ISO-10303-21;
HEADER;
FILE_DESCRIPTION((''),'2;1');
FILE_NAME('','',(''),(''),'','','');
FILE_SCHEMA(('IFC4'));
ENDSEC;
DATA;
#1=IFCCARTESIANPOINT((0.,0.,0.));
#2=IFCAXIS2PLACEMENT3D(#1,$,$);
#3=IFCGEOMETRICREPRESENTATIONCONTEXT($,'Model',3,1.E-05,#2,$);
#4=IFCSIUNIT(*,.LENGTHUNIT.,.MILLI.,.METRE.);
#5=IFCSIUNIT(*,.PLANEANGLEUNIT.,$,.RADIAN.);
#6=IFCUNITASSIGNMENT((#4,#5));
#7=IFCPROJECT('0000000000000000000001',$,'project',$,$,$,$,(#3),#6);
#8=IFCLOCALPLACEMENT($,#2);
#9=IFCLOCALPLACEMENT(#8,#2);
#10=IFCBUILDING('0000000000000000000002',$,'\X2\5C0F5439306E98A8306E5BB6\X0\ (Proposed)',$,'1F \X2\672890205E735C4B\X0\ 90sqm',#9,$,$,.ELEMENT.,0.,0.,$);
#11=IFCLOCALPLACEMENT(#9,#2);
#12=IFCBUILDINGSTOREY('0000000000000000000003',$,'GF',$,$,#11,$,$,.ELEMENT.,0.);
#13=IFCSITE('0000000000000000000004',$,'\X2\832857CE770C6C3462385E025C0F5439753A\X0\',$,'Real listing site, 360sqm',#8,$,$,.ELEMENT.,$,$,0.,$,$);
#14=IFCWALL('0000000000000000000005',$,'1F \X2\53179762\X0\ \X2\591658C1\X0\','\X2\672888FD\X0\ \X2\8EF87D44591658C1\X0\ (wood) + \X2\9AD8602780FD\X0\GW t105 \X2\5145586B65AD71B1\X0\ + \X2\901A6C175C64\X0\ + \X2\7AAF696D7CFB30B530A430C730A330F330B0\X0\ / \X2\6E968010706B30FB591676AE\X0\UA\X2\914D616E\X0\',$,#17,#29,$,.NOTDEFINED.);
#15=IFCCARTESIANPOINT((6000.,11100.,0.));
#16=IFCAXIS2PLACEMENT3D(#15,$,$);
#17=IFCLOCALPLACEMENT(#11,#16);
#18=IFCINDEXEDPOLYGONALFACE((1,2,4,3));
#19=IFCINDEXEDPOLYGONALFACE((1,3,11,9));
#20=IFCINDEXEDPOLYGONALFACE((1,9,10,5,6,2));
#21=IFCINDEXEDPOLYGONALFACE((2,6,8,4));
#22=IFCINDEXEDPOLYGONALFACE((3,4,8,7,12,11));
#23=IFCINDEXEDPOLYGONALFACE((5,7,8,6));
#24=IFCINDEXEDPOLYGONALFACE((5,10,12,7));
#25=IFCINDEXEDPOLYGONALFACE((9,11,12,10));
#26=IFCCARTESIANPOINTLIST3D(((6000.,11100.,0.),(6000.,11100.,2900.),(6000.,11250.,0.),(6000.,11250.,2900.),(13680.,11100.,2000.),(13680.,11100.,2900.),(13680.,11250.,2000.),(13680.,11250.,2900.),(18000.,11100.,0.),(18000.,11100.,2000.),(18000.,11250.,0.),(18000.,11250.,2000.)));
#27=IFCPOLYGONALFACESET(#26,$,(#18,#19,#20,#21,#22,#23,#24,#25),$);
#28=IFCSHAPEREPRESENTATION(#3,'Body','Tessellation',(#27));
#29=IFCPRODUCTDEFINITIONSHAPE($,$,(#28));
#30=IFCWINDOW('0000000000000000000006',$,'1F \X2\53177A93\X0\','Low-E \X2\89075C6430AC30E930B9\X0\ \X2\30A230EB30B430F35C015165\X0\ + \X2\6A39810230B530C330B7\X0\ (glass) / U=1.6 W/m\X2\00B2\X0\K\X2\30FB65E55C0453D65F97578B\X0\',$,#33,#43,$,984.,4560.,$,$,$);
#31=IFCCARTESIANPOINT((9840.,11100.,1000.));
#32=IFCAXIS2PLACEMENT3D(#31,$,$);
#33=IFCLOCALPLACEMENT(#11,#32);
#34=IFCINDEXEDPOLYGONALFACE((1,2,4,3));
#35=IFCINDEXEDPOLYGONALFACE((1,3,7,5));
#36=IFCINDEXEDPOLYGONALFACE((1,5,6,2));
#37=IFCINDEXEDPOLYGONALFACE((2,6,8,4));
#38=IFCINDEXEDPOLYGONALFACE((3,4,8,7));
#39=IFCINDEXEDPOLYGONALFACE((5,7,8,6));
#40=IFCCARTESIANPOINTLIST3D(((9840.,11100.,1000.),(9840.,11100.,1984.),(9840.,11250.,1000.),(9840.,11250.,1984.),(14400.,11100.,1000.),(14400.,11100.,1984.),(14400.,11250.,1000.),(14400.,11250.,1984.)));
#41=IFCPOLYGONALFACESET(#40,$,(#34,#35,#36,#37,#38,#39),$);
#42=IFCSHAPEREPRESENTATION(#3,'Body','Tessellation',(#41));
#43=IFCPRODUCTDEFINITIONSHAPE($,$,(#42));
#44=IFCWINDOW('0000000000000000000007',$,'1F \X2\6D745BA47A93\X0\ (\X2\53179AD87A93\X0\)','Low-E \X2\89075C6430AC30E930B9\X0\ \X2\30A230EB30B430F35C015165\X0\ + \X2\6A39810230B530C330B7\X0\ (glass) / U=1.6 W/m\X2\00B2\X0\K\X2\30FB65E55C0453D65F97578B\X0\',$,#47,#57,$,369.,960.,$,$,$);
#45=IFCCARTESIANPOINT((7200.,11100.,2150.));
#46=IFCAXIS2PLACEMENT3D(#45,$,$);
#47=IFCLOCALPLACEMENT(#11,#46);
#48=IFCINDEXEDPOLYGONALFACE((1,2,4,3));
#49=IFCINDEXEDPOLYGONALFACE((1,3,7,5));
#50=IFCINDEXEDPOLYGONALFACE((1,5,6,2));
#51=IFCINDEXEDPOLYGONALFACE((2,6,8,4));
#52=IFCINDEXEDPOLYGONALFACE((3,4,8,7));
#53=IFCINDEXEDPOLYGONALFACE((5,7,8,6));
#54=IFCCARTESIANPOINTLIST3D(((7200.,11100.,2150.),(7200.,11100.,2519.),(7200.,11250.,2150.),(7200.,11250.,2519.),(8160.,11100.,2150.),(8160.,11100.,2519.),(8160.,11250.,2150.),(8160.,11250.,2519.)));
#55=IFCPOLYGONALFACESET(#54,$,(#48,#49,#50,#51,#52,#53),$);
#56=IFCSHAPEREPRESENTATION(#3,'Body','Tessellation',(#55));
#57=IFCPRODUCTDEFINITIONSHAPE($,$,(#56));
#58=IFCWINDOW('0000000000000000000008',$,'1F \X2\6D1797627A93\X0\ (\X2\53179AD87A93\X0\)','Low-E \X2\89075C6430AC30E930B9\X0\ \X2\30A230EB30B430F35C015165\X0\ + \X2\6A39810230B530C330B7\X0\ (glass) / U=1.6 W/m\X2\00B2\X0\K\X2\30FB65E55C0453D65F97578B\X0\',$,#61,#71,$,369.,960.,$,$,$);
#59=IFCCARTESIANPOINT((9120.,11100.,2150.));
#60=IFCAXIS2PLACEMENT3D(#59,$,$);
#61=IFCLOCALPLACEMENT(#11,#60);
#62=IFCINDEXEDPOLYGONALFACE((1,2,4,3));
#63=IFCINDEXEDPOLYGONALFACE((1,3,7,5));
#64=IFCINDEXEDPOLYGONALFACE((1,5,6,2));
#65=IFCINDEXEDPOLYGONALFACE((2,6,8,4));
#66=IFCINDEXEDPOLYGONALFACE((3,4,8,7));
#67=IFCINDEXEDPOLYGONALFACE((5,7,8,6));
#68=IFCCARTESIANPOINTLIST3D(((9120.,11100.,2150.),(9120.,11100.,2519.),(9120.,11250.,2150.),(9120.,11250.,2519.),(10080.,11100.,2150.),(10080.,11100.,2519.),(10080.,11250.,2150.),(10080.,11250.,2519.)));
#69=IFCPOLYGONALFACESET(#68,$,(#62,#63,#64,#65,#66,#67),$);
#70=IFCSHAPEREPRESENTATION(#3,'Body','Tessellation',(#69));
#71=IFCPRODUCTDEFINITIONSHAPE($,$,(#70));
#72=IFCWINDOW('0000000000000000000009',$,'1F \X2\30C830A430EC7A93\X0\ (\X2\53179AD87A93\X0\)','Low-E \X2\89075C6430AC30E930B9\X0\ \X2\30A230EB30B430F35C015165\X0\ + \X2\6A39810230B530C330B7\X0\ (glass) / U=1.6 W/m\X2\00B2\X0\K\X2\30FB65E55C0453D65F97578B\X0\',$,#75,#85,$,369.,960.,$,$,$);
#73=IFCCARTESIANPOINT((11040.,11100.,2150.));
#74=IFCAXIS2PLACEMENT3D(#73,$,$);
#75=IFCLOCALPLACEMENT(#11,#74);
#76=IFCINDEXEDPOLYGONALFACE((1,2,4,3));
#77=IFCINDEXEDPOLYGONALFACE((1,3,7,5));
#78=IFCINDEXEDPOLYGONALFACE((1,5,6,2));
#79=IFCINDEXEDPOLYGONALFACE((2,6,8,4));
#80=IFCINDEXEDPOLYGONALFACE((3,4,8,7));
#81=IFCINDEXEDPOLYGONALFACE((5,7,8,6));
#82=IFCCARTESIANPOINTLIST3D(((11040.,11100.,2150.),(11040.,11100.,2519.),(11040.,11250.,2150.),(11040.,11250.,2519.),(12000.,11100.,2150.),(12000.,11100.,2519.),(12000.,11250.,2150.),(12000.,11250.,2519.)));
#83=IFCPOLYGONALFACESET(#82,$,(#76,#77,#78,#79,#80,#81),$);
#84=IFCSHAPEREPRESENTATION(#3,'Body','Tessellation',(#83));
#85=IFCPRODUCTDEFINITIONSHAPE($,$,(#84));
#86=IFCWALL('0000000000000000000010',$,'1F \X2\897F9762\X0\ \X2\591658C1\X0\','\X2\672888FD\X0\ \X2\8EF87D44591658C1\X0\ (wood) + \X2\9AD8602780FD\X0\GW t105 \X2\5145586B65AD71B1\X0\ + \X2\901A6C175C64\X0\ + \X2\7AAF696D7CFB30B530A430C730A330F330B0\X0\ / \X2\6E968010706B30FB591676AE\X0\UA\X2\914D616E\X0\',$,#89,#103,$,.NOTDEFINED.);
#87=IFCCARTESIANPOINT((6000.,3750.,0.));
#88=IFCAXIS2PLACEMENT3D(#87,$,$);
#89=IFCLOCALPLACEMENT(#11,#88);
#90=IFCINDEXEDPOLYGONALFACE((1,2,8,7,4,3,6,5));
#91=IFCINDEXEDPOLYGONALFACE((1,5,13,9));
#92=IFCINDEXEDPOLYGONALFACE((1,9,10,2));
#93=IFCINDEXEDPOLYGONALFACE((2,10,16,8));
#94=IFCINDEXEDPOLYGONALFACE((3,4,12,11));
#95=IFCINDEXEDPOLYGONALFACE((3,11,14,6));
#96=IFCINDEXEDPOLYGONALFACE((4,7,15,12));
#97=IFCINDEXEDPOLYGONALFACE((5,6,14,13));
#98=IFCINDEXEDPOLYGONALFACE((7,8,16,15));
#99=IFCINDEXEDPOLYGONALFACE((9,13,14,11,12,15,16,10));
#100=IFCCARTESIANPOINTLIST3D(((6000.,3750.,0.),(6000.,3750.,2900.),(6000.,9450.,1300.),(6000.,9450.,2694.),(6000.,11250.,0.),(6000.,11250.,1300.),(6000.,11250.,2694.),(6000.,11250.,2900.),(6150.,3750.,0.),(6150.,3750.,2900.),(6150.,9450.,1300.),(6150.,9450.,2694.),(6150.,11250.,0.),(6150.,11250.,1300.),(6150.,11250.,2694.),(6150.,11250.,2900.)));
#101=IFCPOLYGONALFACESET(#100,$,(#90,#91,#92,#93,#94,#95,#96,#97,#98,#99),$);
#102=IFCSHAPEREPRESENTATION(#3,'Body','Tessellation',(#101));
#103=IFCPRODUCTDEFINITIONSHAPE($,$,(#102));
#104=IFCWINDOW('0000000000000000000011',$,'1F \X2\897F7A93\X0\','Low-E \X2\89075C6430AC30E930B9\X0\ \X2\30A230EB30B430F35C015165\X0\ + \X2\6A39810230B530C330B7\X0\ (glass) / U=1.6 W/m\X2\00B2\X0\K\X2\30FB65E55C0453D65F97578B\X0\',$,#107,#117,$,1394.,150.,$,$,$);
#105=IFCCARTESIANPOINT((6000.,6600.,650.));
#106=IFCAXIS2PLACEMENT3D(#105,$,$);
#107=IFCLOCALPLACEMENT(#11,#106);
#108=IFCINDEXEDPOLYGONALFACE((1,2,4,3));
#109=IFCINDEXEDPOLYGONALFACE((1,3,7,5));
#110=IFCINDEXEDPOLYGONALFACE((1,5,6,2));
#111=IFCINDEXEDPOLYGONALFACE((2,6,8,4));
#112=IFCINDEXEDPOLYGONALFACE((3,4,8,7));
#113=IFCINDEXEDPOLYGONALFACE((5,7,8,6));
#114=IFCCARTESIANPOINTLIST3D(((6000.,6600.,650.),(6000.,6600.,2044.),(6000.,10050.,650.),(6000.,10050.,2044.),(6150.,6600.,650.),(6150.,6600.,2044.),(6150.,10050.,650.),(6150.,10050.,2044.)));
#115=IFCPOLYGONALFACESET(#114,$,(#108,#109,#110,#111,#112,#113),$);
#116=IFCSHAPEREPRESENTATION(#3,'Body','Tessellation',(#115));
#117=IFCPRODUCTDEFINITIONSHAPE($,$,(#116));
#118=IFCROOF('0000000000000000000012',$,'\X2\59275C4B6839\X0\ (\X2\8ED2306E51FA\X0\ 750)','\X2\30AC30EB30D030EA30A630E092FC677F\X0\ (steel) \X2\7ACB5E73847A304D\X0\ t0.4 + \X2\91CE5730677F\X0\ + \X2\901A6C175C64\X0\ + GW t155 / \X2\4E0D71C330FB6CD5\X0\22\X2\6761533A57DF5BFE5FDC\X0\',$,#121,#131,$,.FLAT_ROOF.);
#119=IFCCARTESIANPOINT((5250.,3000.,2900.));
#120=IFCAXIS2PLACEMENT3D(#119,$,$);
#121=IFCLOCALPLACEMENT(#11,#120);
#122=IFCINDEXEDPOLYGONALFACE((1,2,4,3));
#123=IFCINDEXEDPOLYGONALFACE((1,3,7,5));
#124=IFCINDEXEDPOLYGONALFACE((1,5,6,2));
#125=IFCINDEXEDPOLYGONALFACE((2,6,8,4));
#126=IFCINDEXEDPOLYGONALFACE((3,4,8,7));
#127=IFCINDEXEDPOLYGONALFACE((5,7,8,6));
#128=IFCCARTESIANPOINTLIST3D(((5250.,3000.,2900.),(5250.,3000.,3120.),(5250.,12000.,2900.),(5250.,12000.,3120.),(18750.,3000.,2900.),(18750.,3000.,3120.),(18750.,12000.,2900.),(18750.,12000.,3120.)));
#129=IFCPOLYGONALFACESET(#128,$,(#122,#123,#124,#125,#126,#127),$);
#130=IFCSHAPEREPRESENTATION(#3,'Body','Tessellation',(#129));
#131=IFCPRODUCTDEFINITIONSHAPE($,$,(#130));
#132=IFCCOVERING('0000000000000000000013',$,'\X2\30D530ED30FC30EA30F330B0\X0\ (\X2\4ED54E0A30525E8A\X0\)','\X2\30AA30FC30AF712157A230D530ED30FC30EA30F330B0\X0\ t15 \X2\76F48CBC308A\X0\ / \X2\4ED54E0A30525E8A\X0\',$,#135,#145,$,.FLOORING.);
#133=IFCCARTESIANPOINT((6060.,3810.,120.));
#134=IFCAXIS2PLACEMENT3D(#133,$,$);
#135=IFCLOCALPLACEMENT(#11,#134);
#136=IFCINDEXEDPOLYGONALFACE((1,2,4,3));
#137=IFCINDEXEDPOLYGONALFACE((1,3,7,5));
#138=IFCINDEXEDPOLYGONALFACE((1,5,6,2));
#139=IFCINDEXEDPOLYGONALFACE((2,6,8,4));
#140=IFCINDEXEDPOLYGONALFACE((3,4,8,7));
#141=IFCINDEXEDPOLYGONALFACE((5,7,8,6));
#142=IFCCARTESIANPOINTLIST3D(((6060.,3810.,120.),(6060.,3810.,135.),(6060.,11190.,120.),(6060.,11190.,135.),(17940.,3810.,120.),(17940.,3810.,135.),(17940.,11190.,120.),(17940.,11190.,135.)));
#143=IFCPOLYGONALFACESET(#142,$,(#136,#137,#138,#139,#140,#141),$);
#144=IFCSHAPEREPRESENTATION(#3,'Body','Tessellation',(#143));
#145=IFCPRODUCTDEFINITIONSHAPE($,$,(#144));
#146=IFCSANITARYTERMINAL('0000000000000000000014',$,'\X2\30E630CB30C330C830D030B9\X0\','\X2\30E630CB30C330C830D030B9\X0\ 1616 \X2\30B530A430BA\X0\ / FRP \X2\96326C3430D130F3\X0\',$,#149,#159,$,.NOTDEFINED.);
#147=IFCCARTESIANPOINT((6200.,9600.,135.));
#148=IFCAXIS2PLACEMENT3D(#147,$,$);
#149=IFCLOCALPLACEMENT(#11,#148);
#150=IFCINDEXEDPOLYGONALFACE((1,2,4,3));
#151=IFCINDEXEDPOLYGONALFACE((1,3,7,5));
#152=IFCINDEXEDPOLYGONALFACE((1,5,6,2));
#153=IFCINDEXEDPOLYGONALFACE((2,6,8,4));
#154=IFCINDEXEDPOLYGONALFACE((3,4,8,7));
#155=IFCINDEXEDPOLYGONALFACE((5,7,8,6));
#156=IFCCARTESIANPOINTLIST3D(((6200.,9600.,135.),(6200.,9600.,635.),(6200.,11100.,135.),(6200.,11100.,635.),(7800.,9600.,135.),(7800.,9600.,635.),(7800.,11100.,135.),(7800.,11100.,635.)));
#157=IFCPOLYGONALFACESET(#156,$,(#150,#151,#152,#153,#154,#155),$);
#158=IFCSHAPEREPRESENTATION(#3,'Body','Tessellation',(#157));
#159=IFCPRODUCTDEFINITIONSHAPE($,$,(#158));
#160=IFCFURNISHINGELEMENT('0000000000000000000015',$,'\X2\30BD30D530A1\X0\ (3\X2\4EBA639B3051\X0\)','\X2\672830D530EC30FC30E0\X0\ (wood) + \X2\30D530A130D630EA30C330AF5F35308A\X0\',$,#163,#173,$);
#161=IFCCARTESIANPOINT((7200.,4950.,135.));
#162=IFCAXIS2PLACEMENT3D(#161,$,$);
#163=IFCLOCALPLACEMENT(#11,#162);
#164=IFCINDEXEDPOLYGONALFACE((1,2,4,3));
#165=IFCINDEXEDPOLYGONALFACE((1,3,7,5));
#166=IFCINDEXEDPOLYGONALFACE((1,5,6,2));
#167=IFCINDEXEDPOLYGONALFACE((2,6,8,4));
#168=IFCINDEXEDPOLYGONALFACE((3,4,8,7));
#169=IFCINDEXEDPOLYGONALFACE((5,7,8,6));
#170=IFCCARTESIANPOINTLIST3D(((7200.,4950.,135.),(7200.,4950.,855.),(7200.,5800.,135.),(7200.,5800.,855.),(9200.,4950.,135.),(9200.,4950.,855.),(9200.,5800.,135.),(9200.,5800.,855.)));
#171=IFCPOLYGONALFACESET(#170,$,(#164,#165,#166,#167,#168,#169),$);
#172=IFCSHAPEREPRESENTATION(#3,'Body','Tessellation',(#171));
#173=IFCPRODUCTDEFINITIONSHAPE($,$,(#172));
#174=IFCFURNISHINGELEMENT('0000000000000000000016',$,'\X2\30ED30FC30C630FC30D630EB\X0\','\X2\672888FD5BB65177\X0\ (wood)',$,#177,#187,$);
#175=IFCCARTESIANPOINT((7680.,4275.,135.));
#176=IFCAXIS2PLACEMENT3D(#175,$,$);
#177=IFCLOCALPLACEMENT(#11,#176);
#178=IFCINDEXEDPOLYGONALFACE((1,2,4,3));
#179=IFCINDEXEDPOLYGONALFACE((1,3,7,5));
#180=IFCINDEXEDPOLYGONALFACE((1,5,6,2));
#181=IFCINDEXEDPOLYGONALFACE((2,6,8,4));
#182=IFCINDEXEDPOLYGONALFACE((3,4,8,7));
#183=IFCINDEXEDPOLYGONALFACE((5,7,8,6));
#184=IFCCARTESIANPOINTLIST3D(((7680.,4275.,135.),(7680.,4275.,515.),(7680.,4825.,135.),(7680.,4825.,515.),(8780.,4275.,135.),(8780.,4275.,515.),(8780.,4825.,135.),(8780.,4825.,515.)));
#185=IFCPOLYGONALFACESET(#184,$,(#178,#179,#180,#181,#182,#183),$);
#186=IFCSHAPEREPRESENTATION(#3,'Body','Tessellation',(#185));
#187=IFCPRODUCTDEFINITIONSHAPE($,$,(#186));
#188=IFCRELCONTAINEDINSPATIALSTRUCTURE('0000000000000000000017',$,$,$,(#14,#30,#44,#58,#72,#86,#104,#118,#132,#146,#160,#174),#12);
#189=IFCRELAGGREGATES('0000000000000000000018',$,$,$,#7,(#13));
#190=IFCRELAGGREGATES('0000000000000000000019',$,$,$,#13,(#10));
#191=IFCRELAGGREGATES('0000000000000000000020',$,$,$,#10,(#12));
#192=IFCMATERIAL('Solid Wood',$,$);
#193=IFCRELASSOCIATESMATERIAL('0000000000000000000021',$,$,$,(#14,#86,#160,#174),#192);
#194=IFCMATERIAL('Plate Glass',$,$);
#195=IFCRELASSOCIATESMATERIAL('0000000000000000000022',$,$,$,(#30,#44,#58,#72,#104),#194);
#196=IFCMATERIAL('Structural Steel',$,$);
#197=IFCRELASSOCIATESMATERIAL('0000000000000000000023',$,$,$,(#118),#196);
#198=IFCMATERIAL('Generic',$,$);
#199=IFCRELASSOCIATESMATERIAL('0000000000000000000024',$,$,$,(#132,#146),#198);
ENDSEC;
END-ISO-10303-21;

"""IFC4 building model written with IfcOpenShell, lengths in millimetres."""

from ifc_helpers import new_model, si_unit, frame, frame_2d, origin, place, context, project, spatial, rectangle, extrude, material, element, fill, save


model = new_model("IFC4")

# Units and contexts
model_context = context("Model", 3, precision=1e-05, world=origin())
ifc_project = project(units=[si_unit("LENGTHUNIT", "METRE", prefix="MILLI"), si_unit("PLANEANGLEUNIT", "RADIAN")], contexts=[model_context])

# Site, building, storey
site_placement = place(None, origin())
site = spatial("IfcSite", under=ifc_project, at=site_placement, Name="茨城県水戸市小吹町", ObjectType="Real listing site, 360sqm", CompositionType="ELEMENT", RefElevation=0.0)
building_placement = place(site_placement, origin())
building = spatial("IfcBuilding", under=site, at=building_placement, Name="小吹の風の家 (Proposed)", ObjectType="1F 木造平屋 90sqm", CompositionType="ELEMENT", ElevationOfRefHeight=0.0, ElevationOfTerrain=0.0)
storey_placement = place(building_placement, origin())
storey = spatial("IfcBuildingStorey", under=building, at=storey_placement, Name="GF", CompositionType="ELEMENT", Elevation=0.0)

# Shared definitions
ifc_material_1 = material(Name="Solid Wood")

# Shared definitions
ifc_material_2 = material(Name="Plate Glass")

# Wall, openings, windows
wall_1_placement = place(storey_placement, frame((6000.0, 11100.0, 0.0)))
wall_1 = element("IfcWall", 1, at=wall_1_placement, inside=storey, material=ifc_material_1, Name="1F 北面 外壁", Description="木製 軸組外壁 (wood) + 高性能GW t105 充填断熱 + 通気層 + 窯業系サイディング / 準耐火・外皮UA配慮", PredefinedType="NOTDEFINED", context=model_context, shape_type="SweptSolid", body=[
    extrude(rectangle(XDim=12000.0, YDim=150.0, at=frame_2d((6000.0, 75.0))), frame((6000.0, 11100.0, 0.0)), (0.0, 0.0, 1.0), 2900.0),
])
opening_1_placement = place(storey_placement, frame((9840.0, 11100.0, 1000.0)))
opening_1 = element("IfcOpeningElement", 2, at=opening_1_placement, cuts=wall_1, PredefinedType="NOTDEFINED", context=model_context, shape_type="SweptSolid", body=[
    extrude(rectangle(XDim=4560.0, YDim=150.0, at=frame_2d((2280.0, 75.0))), frame((9840.0, 11100.0, 1000.0)), (0.0, 0.0, 1.0), 984.0),
])
opening_2_placement = place(storey_placement, frame((7200.0, 11100.0, 2150.0)))
opening_2 = element("IfcOpeningElement", 3, at=opening_2_placement, cuts=wall_1, PredefinedType="NOTDEFINED", context=model_context, shape_type="SweptSolid", body=[
    extrude(rectangle(XDim=960.0, YDim=150.0, at=frame_2d((480.0, 75.0))), frame((7200.0, 11100.0, 2150.0)), (0.0, 0.0, 1.0), 369.0),
])
opening_3_placement = place(storey_placement, frame((9120.0, 11100.0, 2150.0)))
opening_3 = element("IfcOpeningElement", 4, at=opening_3_placement, cuts=wall_1, PredefinedType="NOTDEFINED", context=model_context, shape_type="SweptSolid", body=[
    extrude(rectangle(XDim=960.0, YDim=150.0, at=frame_2d((480.0, 75.0))), frame((9120.0, 11100.0, 2150.0)), (0.0, 0.0, 1.0), 369.0),
])
opening_4_placement = place(storey_placement, frame((11040.0, 11100.0, 2150.0)))
opening_4 = element("IfcOpeningElement", 5, at=opening_4_placement, cuts=wall_1, PredefinedType="NOTDEFINED", context=model_context, shape_type="SweptSolid", body=[
    extrude(rectangle(XDim=960.0, YDim=150.0, at=frame_2d((480.0, 75.0))), frame((11040.0, 11100.0, 2150.0)), (0.0, 0.0, 1.0), 369.0),
])
window_1_placement = place(storey_placement, frame((9840.0, 11100.0, 1000.0)))
window_1 = element("IfcWindow", 6, at=window_1_placement, inside=storey, material=ifc_material_2, Name="1F 北窓", Description="Low-E 複層ガラス アルゴン封入 + 樹脂サッシ (glass) / U=1.6 W/m²K・日射取得型", OverallHeight=984.0, OverallWidth=4560.0, context=model_context, shape_type="SweptSolid", body=[
    extrude(rectangle(XDim=4560.0, YDim=150.0, at=frame_2d((2280.0, 75.0))), frame((9840.0, 11100.0, 1000.0)), (0.0, 0.0, 1.0), 984.0),
])
fill(opening_1, window_1)
window_2_placement = place(storey_placement, frame((7200.0, 11100.0, 2150.0)))
window_2 = element("IfcWindow", 7, at=window_2_placement, inside=storey, material=ifc_material_2, Name="1F 浴室窓 (北高窓)", Description="Low-E 複層ガラス アルゴン封入 + 樹脂サッシ (glass) / U=1.6 W/m²K・日射取得型", OverallHeight=369.0, OverallWidth=960.0, context=model_context, shape_type="SweptSolid", body=[
    extrude(rectangle(XDim=960.0, YDim=150.0, at=frame_2d((480.0, 75.0))), frame((7200.0, 11100.0, 2150.0)), (0.0, 0.0, 1.0), 369.0),
])
fill(opening_2, window_2)
window_3_placement = place(storey_placement, frame((9120.0, 11100.0, 2150.0)))
window_3 = element("IfcWindow", 8, at=window_3_placement, inside=storey, material=ifc_material_2, Name="1F 洗面窓 (北高窓)", Description="Low-E 複層ガラス アルゴン封入 + 樹脂サッシ (glass) / U=1.6 W/m²K・日射取得型", OverallHeight=369.0, OverallWidth=960.0, context=model_context, shape_type="SweptSolid", body=[
    extrude(rectangle(XDim=960.0, YDim=150.0, at=frame_2d((480.0, 75.0))), frame((9120.0, 11100.0, 2150.0)), (0.0, 0.0, 1.0), 369.0),
])
fill(opening_3, window_3)
window_4_placement = place(storey_placement, frame((11040.0, 11100.0, 2150.0)))
window_4 = element("IfcWindow", 9, at=window_4_placement, inside=storey, material=ifc_material_2, Name="1F トイレ窓 (北高窓)", Description="Low-E 複層ガラス アルゴン封入 + 樹脂サッシ (glass) / U=1.6 W/m²K・日射取得型", OverallHeight=369.0, OverallWidth=960.0, context=model_context, shape_type="SweptSolid", body=[
    extrude(rectangle(XDim=960.0, YDim=150.0, at=frame_2d((480.0, 75.0))), frame((11040.0, 11100.0, 2150.0)), (0.0, 0.0, 1.0), 369.0),
])
fill(opening_4, window_4)

# Wall, opening, window
wall_2_placement = place(storey_placement, frame((6000.0, 3750.0, 0.0)))
wall_2 = element("IfcWall", 10, at=wall_2_placement, inside=storey, material=ifc_material_1, Name="1F 西面 外壁", Description="木製 軸組外壁 (wood) + 高性能GW t105 充填断熱 + 通気層 + 窯業系サイディング / 準耐火・外皮UA配慮", PredefinedType="NOTDEFINED", context=model_context, shape_type="SweptSolid", body=[
    extrude(rectangle(XDim=150.0, YDim=7500.0, at=frame_2d((75.0, 3750.0))), frame((6000.0, 3750.0, 0.0)), (0.0, 0.0, 1.0), 2900.0),
])
opening_5_placement = place(storey_placement, frame((6000.0, 6600.0, 650.0)))
opening_5 = element("IfcOpeningElement", 11, at=opening_5_placement, cuts=wall_2, PredefinedType="NOTDEFINED", context=model_context, shape_type="SweptSolid", body=[
    extrude(rectangle(XDim=150.0, YDim=3450.0, at=frame_2d((75.0, 1725.0))), frame((6000.0, 6600.0, 650.0)), (0.0, 0.0, 1.0), 1394.0),
])
window_5_placement = place(storey_placement, frame((6000.0, 6600.0, 650.0)))
window_5 = element("IfcWindow", 12, at=window_5_placement, inside=storey, material=ifc_material_2, Name="1F 西窓", Description="Low-E 複層ガラス アルゴン封入 + 樹脂サッシ (glass) / U=1.6 W/m²K・日射取得型", OverallHeight=1394.0, OverallWidth=150.0, context=model_context, shape_type="SweptSolid", body=[
    extrude(rectangle(XDim=150.0, YDim=3450.0, at=frame_2d((75.0, 1725.0))), frame((6000.0, 6600.0, 650.0)), (0.0, 0.0, 1.0), 1394.0),
])
fill(opening_5, window_5)

# Roof
ifc_material_3 = material(Name="Structural Steel")
roof_placement = place(storey_placement, frame((5250.0, 3000.0, 2900.0)))
element("IfcRoof", 13, at=roof_placement, inside=storey, material=ifc_material_3, Name="大屋根 (軒の出 750)", Description="ガルバリウム鋼板 (steel) 立平葺き t0.4 + 野地板 + 通気層 + GW t155 / 不燃・法22条区域対応", PredefinedType="FLAT_ROOF", context=model_context, shape_type="SweptSolid", body=[
    extrude(rectangle(XDim=13500.0, YDim=9000.0, at=frame_2d((6750.0, 4500.0))), frame((5250.0, 3000.0, 2900.0)), (0.0, 0.0, 1.0), 220.0),
])

# Covering
ifc_material_4 = material(Name="Generic")
covering_placement = place(storey_placement, frame((6060.0, 3810.0, 120.0)))
element("IfcCovering", 14, at=covering_placement, inside=storey, material=ifc_material_4, Name="フローリング (仕上げ床)", Description="オーク無垢フローリング t15 直貼り / 仕上げ床", PredefinedType="FLOORING", context=model_context, shape_type="SweptSolid", body=[
    extrude(rectangle(XDim=11880.0, YDim=7380.0, at=frame_2d((5940.0, 3690.0))), frame((6060.0, 3810.0, 120.0)), (0.0, 0.0, 1.0), 15.0),
])

# Sanitary terminal
sanitary_terminal_placement = place(storey_placement, frame((6200.0, 9600.0, 135.0)))
element("IfcSanitaryTerminal", 15, at=sanitary_terminal_placement, inside=storey, material=ifc_material_4, Name="ユニットバス", Description="ユニットバス 1616 サイズ / FRP 防水パン", PredefinedType="NOTDEFINED", context=model_context, shape_type="SweptSolid", body=[
    extrude(rectangle(XDim=1600.0, YDim=1500.0, at=frame_2d((800.0, 750.0))), frame((6200.0, 9600.0, 135.0)), (0.0, 0.0, 1.0), 500.0),
])

# Furnishing elements
furnishing_1_placement = place(storey_placement, frame((7200.0, 4950.0, 135.0)))
element("IfcFurnishingElement", 16, at=furnishing_1_placement, inside=storey, material=ifc_material_1, Name="ソファ (3人掛け)", Description="木フレーム (wood) + ファブリック張り", context=model_context, shape_type="SweptSolid", body=[
    extrude(rectangle(XDim=2000.0, YDim=850.0, at=frame_2d((1000.0, 425.0))), frame((7200.0, 4950.0, 135.0)), (0.0, 0.0, 1.0), 720.0),
])
furnishing_2_placement = place(storey_placement, frame((7680.0, 4275.0, 135.0)))
element("IfcFurnishingElement", 17, at=furnishing_2_placement, inside=storey, material=ifc_material_1, Name="ローテーブル", Description="木製家具 (wood)", context=model_context, shape_type="SweptSolid", body=[
    extrude(rectangle(XDim=1100.0, YDim=550.0, at=frame_2d((550.0, 275.0))), frame((7680.0, 4275.0, 135.0)), (0.0, 0.0, 1.0), 380.0),
])

save(model, "model.ifc")
